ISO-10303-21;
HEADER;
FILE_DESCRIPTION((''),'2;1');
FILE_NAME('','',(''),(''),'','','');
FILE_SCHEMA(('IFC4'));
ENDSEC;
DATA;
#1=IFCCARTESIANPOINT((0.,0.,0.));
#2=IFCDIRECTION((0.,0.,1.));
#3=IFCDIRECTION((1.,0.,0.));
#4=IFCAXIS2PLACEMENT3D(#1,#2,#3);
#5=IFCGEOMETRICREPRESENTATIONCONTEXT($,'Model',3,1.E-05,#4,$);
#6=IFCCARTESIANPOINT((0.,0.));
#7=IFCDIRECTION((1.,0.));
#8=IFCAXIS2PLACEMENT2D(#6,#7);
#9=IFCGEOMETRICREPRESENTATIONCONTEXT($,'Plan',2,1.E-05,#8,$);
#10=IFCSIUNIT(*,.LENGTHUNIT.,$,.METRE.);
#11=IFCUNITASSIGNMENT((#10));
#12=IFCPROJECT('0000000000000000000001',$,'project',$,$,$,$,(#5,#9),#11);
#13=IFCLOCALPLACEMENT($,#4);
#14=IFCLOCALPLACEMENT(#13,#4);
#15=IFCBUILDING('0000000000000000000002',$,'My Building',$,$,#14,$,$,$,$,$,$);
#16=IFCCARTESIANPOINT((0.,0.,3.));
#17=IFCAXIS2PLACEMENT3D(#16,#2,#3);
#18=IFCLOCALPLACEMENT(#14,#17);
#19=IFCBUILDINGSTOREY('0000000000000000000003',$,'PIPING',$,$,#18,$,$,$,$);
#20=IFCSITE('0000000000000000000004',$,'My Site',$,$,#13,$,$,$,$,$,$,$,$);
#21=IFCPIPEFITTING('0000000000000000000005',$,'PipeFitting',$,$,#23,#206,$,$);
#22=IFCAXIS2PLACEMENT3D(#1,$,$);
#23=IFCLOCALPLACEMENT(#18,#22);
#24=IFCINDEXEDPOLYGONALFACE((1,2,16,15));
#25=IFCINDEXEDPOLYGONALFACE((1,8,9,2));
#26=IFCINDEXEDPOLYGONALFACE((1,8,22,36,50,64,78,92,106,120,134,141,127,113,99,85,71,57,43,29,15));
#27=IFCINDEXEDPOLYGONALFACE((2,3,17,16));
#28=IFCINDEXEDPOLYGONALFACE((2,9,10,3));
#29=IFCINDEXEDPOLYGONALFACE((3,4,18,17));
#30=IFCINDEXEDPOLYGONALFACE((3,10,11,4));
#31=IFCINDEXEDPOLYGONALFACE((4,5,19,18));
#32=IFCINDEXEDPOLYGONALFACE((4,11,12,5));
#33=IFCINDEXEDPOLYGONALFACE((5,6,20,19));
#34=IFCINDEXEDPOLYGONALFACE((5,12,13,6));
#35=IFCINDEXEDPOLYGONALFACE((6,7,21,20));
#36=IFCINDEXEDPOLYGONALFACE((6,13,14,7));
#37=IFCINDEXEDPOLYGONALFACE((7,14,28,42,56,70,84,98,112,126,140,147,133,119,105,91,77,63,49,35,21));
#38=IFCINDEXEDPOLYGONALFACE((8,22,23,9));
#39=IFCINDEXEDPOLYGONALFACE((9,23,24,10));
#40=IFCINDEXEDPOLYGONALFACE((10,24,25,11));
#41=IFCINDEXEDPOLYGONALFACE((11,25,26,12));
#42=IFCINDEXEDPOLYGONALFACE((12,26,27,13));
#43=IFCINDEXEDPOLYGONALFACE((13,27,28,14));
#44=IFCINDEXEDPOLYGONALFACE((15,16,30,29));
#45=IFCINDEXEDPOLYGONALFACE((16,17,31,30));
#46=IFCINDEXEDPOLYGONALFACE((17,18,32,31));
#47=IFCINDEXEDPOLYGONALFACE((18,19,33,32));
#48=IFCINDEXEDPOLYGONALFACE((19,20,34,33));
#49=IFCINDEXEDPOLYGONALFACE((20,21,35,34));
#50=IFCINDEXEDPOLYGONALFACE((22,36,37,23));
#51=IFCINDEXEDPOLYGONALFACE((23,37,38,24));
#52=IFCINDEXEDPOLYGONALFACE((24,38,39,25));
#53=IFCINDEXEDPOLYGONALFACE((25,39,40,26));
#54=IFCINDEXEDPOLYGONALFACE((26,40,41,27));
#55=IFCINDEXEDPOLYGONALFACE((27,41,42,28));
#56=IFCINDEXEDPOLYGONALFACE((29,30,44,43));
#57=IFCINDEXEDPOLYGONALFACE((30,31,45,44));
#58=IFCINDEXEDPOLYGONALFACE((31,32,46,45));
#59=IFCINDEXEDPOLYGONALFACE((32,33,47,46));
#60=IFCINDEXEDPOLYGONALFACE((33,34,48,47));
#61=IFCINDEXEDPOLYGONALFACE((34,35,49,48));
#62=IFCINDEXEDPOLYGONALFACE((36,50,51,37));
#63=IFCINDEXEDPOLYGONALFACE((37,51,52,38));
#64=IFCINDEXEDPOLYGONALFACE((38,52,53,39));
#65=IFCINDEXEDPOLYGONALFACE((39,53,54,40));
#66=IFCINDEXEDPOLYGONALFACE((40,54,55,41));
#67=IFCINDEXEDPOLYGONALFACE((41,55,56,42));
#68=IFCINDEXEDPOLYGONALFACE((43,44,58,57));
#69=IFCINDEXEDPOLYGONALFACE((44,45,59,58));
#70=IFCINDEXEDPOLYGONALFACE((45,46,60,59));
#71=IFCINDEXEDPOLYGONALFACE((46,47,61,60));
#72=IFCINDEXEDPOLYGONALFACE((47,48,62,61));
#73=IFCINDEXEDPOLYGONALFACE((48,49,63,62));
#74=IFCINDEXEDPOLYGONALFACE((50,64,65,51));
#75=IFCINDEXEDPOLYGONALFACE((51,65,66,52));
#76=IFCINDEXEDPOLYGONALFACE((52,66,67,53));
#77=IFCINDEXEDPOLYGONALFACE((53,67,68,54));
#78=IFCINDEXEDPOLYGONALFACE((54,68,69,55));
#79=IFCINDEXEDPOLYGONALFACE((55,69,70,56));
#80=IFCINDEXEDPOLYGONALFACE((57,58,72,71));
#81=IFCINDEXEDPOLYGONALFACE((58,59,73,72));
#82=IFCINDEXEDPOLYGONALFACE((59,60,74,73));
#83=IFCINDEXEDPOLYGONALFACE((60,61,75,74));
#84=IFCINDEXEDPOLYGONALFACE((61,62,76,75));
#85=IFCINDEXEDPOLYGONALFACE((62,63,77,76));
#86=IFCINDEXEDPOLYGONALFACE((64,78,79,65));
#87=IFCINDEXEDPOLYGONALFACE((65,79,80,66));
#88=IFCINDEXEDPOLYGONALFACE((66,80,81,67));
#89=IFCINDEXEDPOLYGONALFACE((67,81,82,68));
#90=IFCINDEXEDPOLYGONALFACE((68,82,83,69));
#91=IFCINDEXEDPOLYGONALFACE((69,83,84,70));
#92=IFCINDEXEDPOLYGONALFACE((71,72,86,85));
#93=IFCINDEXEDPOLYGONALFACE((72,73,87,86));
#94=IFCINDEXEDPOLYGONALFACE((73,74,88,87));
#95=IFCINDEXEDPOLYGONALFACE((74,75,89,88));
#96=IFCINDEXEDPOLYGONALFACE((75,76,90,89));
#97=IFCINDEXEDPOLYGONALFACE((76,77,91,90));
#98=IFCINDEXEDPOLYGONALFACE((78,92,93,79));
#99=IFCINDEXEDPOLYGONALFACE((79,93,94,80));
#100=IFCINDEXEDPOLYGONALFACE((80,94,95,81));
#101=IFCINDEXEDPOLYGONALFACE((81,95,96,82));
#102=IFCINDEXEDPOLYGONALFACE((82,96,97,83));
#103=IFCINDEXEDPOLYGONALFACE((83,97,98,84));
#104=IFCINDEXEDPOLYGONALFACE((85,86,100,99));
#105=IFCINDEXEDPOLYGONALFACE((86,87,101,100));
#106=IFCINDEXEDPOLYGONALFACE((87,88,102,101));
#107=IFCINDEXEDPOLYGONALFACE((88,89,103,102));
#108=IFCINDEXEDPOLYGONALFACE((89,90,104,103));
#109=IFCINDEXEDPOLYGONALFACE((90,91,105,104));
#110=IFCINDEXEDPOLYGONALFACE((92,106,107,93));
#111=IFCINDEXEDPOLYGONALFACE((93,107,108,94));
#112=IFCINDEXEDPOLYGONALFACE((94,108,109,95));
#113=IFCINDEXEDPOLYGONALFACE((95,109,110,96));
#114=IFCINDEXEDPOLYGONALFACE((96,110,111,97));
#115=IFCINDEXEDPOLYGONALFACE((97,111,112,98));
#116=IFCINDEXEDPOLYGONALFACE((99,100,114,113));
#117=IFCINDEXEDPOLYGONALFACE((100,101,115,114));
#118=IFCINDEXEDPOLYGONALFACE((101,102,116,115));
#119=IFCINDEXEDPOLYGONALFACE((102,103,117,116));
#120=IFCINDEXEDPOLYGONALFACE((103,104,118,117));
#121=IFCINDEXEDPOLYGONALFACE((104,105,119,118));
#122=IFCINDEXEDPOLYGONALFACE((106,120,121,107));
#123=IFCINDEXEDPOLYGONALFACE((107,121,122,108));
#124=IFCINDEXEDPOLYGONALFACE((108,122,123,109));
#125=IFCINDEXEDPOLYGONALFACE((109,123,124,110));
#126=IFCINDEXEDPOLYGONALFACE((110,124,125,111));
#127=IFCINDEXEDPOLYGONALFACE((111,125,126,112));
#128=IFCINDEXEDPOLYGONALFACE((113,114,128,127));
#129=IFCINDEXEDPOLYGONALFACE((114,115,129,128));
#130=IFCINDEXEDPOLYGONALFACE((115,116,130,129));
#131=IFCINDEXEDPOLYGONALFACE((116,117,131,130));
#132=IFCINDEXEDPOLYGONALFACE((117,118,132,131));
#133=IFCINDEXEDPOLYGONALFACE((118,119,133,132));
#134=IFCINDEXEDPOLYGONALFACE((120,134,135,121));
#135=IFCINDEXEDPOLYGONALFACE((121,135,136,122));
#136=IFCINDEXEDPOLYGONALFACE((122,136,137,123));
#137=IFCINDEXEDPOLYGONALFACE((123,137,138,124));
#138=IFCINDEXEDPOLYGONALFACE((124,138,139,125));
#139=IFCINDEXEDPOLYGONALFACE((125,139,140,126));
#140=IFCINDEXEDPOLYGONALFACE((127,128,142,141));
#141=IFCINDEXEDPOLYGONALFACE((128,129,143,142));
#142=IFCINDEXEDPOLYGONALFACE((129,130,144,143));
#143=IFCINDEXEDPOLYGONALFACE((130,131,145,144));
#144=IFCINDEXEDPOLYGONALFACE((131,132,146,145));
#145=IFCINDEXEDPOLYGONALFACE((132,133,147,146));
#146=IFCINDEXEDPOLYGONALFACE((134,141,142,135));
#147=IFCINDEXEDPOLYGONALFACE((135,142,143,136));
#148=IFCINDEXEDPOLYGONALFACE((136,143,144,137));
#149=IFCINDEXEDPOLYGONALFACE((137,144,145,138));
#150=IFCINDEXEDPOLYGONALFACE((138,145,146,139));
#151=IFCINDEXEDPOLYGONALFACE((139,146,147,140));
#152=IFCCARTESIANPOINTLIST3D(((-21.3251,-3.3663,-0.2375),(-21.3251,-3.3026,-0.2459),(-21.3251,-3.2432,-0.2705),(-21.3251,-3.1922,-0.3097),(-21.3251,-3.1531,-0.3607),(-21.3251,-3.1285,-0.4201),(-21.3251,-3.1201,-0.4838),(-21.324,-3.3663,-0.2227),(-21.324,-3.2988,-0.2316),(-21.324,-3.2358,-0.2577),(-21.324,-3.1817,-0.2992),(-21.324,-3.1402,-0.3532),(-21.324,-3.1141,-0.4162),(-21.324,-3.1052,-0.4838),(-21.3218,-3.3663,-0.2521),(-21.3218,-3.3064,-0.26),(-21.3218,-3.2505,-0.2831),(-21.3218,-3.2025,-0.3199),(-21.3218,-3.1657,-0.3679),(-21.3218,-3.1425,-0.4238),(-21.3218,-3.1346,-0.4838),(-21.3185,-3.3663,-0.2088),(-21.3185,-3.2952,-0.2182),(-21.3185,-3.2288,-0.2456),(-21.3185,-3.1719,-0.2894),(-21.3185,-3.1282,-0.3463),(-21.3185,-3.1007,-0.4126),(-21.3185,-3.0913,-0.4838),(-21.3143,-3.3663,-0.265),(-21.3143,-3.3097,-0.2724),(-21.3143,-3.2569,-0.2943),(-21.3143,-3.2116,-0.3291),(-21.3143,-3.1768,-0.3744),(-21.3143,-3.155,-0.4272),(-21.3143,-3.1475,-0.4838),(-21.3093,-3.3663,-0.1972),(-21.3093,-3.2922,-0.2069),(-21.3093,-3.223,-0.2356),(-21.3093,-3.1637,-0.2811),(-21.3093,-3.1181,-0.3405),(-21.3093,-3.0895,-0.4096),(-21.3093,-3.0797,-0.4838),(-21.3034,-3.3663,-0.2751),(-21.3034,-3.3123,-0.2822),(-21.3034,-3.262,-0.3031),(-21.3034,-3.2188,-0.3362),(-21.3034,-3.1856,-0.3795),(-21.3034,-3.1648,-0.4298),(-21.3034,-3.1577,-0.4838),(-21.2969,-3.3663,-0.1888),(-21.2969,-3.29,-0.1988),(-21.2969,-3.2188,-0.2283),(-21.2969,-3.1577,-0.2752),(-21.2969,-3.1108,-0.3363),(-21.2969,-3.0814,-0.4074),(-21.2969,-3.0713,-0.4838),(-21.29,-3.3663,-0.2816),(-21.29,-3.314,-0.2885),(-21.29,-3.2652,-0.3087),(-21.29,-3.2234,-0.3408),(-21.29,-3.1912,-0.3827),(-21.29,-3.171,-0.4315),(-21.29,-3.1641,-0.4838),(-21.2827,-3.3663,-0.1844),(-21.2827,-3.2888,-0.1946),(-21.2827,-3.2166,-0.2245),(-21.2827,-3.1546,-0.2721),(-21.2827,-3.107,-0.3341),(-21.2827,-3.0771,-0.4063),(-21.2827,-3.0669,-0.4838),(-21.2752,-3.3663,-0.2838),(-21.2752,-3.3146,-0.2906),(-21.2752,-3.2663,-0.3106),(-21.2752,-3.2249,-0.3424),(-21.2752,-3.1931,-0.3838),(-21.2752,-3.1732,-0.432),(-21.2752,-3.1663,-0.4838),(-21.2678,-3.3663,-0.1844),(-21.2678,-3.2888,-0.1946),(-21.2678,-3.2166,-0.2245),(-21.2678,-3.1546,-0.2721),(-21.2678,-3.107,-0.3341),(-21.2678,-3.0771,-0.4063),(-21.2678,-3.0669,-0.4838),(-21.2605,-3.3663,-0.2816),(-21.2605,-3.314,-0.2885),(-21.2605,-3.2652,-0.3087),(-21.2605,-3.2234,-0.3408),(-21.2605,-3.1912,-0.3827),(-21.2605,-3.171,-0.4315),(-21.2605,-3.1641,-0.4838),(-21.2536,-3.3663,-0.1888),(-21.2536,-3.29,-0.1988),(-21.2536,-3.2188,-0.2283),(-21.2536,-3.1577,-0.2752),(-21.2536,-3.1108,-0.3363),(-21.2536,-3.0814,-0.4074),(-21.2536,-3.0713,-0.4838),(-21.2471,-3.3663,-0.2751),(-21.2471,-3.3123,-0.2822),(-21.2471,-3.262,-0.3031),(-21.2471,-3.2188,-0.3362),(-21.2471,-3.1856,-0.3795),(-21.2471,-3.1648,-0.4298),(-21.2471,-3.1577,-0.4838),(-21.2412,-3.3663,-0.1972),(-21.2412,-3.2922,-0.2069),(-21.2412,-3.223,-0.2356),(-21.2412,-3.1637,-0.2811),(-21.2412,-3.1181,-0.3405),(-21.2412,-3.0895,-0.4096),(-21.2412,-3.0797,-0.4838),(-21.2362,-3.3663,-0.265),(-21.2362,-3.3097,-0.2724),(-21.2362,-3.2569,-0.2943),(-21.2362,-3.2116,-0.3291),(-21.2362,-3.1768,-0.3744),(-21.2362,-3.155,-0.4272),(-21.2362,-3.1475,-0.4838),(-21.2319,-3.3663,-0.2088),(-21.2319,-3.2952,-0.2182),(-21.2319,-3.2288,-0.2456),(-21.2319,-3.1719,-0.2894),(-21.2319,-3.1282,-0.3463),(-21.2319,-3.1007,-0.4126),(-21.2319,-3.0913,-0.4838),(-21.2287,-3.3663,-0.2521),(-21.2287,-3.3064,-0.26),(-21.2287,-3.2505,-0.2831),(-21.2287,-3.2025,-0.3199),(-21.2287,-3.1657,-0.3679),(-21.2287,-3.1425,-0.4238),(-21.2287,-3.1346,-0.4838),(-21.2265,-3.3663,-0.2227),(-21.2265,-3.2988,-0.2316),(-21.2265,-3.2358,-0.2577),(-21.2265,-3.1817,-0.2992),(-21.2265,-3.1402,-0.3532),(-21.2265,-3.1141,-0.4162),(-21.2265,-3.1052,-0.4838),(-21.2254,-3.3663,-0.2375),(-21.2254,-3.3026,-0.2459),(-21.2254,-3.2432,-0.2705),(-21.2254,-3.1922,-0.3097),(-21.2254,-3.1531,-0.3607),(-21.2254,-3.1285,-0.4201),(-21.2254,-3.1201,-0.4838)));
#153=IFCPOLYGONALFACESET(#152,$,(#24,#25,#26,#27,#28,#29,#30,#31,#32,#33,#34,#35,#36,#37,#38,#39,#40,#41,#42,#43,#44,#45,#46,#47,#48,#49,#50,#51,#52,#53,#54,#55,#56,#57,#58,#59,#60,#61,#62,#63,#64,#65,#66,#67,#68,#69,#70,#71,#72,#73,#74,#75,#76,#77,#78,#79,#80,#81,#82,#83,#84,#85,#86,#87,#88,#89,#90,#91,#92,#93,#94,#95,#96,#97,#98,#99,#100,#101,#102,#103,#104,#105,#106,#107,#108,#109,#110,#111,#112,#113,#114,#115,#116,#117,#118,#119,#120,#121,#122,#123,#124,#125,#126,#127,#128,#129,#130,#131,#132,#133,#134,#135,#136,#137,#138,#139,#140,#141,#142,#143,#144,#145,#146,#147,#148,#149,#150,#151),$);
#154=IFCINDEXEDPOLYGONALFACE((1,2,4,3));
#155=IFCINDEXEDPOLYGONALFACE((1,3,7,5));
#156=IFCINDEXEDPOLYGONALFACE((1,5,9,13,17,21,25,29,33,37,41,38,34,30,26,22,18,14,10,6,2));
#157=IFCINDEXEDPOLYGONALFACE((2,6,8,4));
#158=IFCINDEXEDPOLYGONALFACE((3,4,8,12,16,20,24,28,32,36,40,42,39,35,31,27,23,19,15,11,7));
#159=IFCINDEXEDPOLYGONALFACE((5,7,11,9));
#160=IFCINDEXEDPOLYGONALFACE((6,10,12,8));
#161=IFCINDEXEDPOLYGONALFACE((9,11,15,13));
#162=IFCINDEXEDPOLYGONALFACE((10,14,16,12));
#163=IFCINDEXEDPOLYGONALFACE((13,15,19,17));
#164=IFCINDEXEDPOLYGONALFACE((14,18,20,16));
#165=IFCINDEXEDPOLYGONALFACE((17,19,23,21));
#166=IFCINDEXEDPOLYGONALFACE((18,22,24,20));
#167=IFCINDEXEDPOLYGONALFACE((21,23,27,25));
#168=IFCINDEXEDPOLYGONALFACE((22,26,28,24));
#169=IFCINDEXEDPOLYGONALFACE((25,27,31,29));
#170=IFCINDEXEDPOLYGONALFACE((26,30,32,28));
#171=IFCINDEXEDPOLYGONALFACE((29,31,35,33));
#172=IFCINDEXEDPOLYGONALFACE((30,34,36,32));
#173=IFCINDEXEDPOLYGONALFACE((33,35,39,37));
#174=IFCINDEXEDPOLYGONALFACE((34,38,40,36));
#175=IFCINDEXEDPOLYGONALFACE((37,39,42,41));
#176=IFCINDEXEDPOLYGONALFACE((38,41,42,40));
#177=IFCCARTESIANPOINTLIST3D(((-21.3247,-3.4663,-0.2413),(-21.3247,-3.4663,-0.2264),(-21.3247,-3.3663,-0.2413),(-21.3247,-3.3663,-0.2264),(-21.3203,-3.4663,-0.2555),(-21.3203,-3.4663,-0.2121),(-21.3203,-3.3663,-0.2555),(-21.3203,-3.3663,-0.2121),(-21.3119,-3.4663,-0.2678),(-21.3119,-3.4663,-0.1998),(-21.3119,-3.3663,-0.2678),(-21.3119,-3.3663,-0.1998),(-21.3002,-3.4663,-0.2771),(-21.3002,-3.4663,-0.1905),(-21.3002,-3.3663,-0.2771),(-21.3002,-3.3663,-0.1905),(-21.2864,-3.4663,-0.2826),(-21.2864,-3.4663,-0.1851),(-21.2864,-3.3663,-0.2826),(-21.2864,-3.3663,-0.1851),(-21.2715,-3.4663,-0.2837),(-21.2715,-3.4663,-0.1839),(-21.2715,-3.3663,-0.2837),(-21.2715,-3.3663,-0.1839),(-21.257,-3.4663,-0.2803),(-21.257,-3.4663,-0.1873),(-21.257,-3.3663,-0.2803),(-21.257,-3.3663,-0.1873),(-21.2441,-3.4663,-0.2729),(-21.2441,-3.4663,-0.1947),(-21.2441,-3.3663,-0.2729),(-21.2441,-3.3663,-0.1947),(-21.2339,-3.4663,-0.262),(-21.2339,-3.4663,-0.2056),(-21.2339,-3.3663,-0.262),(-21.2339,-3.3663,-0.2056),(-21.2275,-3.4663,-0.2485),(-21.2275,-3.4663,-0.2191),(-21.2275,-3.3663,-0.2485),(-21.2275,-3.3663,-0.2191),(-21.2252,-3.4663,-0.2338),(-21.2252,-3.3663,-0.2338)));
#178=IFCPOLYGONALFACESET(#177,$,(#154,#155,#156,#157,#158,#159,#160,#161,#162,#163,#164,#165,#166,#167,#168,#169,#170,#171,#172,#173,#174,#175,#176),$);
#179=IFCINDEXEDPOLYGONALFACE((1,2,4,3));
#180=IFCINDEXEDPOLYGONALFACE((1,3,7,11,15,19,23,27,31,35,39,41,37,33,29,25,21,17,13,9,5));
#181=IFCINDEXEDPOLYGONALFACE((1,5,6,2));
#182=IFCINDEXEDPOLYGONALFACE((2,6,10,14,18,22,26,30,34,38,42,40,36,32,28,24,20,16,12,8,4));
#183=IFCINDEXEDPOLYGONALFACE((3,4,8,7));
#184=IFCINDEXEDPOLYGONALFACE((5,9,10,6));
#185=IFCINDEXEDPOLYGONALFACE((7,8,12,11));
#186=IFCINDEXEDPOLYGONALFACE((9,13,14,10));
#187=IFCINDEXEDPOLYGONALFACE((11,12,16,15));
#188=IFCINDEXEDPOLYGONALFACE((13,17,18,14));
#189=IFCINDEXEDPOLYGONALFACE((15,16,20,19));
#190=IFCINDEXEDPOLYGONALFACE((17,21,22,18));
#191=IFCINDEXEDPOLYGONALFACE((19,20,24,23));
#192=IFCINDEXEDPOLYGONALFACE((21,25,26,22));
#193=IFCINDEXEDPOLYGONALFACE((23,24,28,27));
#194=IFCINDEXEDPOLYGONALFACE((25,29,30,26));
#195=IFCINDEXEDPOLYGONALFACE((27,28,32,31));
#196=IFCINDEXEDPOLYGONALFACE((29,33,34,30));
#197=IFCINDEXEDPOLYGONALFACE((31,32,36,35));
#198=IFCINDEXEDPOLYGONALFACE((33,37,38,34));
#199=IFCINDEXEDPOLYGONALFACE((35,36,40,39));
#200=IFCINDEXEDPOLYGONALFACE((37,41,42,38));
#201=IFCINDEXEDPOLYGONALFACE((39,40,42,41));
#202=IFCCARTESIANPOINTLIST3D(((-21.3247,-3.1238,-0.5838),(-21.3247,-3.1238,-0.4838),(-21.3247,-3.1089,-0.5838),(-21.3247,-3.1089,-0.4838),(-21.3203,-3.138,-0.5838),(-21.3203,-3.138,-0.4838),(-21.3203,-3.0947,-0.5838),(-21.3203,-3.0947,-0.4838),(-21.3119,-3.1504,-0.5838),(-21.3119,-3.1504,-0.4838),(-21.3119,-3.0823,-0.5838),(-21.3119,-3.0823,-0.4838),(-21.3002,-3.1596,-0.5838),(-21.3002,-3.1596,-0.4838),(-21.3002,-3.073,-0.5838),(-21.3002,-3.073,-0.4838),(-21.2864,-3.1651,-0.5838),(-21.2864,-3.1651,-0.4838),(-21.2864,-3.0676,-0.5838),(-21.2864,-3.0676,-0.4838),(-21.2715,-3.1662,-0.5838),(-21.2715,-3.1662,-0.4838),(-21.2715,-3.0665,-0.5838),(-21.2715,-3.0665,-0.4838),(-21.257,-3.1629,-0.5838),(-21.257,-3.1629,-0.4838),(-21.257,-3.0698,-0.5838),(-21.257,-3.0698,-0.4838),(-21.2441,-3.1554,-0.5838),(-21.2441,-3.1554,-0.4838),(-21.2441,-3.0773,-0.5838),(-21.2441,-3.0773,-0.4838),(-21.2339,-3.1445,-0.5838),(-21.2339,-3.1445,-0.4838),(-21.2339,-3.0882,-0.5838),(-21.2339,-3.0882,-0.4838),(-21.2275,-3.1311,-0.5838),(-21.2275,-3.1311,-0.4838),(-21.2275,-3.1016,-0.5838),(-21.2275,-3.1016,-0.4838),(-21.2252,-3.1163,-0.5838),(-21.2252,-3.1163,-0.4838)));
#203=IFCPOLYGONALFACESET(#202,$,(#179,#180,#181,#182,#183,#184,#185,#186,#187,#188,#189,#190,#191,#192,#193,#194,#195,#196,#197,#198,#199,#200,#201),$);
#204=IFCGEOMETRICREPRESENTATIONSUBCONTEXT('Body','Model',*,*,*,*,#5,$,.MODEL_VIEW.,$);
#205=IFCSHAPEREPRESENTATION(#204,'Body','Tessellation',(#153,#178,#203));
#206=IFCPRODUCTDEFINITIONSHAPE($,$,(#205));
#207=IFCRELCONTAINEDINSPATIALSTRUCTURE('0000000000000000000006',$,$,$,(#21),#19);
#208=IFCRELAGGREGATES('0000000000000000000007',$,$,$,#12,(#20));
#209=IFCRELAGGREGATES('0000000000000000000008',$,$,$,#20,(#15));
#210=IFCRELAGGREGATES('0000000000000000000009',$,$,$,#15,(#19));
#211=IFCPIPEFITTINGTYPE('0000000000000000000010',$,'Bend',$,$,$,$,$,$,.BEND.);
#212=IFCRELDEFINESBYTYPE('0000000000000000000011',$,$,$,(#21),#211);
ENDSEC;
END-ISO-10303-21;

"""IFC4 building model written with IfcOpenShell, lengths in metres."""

from ifc_helpers import new_model, entity, si_unit, frame, origin_with_axes, origin_2d_with_axis, place, context, subcontext, project, spatial, circle, extrude, source, transform, mapped, type_object, type_shapes, element, save


model = new_model("IFC4")

# Units and contexts
model_context = context("Model", 3, precision=1e-05, world=origin_with_axes())
plan_context = context("Plan", 2, precision=1e-05, world=origin_2d_with_axis())
body_context = subcontext(model_context, "Body", "Model", "MODEL_VIEW")
ifc_project = project(units=[si_unit("LENGTHUNIT", "METRE")], contexts=[model_context, plan_context])

# Site, building, storey
site_placement = place(None, origin_with_axes())
site = spatial("IfcSite", under=ifc_project, at=site_placement, Name="My Site")
building_placement = place(site_placement, origin_with_axes())
building = spatial("IfcBuilding", under=site, at=building_placement, Name="My Building")
storey_placement = place(building_placement, frame((0.0, 0.0, 3.0), z_axis=(0.0, 0.0, 1.0), x_axis=(1.0, 0.0, 0.0)))
storey = spatial("IfcBuildingStorey", under=building, at=storey_placement, Name="PIPING")

# Pipe fitting
pipe_fitting_type = type_object("IfcPipeFittingType", Name="Bend", PredefinedType="BEND")
shared_shape = source(origin_with_axes(), body_context, "Body", "SolidModel", [
    entity("IfcSweptDiskSolid", entity("IfcIndexedPolyCurve", entity("IfcCartesianPointList3D", [[0.0, 0.0, -0.1], [0.0, -0.0732, -0.2768], [0.0, -0.25, -0.35]]), [entity("IfcArcIndex", [1, 2, 3])]), 0.05),
    extrude(circle(Radius=0.05), origin_with_axes(), (0.0, 0.0, -1.0), 0.1),
    extrude(circle(Radius=0.05), frame((0.0, -0.25, -0.35), z_axis=(0.0, -1.0, 0.0), x_axis=(1.0, 0.0, 0.0)), (0.0, 0.0, 1.0), 0.1),
])
type_shapes(pipe_fitting_type, [shared_shape])
for number, where, z_axis, x_axis, name in (
    (1, (-21.2752, -3.4663, -0.2338), (0.0, -1.0, 0.0), (1.0, 0.0, 0.0), "PipeFitting"),
):
    element("IfcPipeFitting", number, at=place(storey_placement, frame(where, z_axis=z_axis, x_axis=x_axis)), inside=storey, type_object=pipe_fitting_type, Name=name, context=body_context, shape_type="MappedRepresentation", body=[
        mapped(shared_shape, transform((0.0, 0.0, 0.0), x_axis=(1.0, 0.0, 0.0), y_axis=(0.0, 1.0, 0.0), z_axis=(0.0, 0.0, 1.0), scale=1.0)),
    ])

save(model, "model.ifc")
